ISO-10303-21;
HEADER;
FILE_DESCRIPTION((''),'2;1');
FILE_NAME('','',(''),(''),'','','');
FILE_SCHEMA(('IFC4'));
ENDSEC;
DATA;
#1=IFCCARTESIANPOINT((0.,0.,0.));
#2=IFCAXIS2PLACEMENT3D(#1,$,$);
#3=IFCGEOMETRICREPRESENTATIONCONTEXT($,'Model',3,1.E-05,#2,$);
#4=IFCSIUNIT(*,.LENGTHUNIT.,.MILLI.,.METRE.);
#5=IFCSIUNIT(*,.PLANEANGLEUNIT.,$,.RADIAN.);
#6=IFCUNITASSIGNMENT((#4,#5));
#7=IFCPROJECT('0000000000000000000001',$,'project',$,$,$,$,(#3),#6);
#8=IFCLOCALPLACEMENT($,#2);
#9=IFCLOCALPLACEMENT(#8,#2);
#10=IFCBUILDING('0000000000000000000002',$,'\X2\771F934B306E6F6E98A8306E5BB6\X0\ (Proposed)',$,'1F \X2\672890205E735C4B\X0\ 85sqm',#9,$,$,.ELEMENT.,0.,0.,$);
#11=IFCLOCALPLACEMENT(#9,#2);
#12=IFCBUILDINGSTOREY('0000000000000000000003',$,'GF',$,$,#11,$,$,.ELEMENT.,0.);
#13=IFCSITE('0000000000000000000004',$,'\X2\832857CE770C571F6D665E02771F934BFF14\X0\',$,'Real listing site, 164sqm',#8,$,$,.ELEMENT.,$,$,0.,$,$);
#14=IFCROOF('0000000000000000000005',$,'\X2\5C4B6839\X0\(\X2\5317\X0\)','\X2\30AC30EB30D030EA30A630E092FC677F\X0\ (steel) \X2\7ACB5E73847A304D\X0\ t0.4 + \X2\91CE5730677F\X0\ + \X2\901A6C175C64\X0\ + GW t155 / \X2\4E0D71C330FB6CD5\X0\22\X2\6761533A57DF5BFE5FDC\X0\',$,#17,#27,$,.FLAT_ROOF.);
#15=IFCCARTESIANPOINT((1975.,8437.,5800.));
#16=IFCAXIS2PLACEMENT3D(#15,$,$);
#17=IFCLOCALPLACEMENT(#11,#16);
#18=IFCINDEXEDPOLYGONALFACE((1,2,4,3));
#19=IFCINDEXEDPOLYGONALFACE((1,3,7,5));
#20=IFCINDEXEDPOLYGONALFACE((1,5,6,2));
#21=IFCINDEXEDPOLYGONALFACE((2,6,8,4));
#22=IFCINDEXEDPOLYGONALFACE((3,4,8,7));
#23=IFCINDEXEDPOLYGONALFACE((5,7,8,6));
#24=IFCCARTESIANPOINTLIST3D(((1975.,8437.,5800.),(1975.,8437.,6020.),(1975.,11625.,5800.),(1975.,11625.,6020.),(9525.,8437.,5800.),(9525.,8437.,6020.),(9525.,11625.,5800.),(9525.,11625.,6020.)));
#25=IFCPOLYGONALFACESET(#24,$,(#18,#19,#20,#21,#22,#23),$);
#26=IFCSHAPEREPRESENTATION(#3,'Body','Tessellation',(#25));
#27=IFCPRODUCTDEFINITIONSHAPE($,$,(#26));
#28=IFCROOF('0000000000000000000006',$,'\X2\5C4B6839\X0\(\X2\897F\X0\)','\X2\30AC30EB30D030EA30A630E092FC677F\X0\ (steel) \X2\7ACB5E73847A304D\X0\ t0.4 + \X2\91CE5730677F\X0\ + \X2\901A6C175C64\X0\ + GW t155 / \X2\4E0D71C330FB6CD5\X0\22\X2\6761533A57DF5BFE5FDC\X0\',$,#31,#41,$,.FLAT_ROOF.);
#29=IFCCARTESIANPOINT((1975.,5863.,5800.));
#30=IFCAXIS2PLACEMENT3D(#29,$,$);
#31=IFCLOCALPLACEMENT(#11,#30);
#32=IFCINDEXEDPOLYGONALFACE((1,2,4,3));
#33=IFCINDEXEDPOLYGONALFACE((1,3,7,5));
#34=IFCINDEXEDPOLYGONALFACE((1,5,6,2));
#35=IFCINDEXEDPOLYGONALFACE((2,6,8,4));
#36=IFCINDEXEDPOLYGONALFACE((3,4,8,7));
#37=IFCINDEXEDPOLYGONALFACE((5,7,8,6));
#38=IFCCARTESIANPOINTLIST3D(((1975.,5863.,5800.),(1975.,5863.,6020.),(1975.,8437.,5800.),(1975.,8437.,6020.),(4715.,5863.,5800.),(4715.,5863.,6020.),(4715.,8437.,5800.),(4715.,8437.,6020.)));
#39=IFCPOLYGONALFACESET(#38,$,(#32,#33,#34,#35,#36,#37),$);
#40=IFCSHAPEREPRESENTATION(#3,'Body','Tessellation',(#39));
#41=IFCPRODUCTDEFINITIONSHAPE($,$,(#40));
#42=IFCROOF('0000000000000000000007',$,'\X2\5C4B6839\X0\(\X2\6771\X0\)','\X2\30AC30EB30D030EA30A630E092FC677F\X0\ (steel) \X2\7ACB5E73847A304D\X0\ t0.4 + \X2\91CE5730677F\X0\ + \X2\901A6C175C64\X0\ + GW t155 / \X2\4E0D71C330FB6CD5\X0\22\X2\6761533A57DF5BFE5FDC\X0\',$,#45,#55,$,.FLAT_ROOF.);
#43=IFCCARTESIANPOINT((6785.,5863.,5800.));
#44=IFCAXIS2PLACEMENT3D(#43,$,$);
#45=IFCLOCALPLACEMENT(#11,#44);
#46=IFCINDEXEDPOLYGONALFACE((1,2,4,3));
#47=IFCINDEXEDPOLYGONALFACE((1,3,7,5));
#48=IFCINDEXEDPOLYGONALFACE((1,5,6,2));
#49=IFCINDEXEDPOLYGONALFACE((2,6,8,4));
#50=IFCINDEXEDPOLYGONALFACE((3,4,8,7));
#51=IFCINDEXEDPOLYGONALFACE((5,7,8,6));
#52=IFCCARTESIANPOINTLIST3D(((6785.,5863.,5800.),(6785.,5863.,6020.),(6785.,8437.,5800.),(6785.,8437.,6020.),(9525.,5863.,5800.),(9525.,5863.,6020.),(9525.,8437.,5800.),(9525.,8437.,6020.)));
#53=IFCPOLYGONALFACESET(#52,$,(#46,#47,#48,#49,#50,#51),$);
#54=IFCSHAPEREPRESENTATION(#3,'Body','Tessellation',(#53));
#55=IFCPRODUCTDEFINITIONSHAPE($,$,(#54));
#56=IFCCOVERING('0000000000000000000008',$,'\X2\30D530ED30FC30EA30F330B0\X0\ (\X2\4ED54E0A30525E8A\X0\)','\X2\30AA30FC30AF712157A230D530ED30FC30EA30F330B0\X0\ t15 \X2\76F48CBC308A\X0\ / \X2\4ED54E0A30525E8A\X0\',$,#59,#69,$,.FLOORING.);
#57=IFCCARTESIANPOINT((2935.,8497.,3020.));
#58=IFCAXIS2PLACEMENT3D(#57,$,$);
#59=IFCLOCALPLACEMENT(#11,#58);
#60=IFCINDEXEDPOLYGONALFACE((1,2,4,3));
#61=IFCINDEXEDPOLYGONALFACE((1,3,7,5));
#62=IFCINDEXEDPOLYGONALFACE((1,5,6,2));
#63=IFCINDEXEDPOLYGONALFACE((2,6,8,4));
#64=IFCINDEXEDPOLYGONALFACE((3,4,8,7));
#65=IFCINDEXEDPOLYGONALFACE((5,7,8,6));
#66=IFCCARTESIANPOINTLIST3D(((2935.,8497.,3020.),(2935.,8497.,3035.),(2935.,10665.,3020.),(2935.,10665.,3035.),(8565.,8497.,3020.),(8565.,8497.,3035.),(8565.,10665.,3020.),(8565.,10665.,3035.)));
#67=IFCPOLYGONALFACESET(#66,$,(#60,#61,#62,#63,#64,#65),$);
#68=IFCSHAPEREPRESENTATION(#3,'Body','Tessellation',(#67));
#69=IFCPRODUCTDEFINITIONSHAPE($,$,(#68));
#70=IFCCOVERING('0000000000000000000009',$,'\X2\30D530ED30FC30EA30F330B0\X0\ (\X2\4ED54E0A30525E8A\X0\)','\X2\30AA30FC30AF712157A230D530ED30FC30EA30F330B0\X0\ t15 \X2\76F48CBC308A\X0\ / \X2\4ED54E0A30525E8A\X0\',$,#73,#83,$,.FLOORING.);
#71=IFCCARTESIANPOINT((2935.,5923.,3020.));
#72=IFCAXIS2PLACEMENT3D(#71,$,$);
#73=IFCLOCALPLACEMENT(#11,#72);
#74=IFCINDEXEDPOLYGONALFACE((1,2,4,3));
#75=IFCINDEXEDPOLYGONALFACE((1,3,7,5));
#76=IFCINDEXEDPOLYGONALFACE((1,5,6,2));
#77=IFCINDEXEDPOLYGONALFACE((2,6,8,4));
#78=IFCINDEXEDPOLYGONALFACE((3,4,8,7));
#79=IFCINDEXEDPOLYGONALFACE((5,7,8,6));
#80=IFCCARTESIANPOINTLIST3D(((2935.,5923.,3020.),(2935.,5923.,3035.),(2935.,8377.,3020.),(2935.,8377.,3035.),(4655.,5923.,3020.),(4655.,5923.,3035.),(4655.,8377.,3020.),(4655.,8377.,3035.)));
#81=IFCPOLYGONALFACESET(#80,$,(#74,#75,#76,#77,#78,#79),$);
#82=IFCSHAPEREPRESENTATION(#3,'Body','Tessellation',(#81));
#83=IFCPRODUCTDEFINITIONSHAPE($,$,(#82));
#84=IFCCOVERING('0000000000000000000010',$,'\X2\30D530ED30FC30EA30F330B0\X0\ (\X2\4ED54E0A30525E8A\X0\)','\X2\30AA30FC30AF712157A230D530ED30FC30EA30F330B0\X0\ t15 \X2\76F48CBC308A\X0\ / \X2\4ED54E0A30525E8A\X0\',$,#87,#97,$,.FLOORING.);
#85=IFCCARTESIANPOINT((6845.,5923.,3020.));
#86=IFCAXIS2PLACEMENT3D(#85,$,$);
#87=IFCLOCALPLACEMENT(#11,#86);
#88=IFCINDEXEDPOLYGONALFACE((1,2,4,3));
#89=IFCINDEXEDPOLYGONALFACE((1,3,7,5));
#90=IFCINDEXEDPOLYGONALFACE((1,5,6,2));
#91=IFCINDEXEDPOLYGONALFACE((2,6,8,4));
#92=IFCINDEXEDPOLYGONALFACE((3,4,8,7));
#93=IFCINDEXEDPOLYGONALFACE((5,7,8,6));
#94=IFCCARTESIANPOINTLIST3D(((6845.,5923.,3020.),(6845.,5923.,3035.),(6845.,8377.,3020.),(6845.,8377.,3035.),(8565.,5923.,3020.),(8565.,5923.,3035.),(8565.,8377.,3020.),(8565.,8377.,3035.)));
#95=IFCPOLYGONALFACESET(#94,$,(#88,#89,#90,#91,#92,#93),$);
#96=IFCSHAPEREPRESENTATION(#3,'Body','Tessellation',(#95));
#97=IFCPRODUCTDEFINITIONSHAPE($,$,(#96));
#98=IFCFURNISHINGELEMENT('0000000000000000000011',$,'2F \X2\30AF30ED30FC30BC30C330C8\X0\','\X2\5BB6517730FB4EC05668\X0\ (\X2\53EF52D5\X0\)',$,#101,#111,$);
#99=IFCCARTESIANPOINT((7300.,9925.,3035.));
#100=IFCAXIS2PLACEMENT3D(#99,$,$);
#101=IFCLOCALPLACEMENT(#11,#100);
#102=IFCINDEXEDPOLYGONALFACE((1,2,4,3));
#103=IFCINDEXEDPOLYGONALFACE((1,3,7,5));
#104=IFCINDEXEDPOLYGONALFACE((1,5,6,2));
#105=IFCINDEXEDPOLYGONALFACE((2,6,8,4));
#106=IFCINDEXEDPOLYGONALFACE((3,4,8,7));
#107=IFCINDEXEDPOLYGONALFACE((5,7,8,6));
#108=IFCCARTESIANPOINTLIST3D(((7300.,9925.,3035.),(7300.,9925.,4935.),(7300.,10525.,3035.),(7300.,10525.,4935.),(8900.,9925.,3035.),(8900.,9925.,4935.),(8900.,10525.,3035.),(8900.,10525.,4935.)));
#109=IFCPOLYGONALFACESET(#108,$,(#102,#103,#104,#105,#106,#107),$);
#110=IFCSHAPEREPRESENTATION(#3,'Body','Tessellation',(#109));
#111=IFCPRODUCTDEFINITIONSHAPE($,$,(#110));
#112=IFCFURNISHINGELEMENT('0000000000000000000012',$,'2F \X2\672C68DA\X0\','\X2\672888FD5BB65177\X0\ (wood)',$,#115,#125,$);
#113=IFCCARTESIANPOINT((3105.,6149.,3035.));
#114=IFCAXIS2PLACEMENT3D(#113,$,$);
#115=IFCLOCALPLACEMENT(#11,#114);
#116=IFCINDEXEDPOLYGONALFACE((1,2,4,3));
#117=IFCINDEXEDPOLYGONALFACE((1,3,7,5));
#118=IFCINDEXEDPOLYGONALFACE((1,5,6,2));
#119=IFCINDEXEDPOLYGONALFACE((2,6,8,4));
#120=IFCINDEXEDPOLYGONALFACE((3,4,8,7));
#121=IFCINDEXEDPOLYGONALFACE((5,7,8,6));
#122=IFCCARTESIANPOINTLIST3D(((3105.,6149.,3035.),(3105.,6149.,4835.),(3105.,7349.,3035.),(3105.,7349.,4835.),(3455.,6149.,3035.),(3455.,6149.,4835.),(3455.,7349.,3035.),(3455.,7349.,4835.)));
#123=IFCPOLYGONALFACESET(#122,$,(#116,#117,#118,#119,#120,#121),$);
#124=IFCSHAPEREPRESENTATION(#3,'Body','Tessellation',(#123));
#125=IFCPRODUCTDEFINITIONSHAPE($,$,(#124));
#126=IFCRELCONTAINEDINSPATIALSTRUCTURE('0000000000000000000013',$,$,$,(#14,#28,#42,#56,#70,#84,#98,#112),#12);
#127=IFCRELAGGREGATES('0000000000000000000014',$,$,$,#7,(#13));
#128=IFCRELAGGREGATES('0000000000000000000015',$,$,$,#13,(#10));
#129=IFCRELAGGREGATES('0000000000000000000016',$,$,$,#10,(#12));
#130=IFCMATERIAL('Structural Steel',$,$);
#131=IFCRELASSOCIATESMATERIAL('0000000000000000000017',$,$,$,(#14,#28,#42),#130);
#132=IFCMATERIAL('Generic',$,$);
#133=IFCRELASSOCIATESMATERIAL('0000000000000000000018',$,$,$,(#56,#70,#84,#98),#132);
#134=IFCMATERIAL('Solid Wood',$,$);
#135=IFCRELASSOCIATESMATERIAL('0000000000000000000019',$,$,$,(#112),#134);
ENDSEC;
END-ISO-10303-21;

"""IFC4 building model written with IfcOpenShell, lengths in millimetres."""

from ifc_helpers import new_model, si_unit, frame, frame_2d, origin, place, context, project, spatial, rectangle, extrude, material, element, save


model = new_model("IFC4")

# Units and contexts
model_context = context("Model", 3, precision=1e-05, world=origin())
ifc_project = project(units=[si_unit("LENGTHUNIT", "METRE", prefix="MILLI"), si_unit("PLANEANGLEUNIT", "RADIAN")], contexts=[model_context])

# Site, building, storey
site_placement = place(None, origin())
site = spatial("IfcSite", under=ifc_project, at=site_placement, Name="茨城県土浦市真鍋４", ObjectType="Real listing site, 164sqm", CompositionType="ELEMENT", RefElevation=0.0)
building_placement = place(site_placement, origin())
building = spatial("IfcBuilding", under=site, at=building_placement, Name="真鍋の潮風の家 (Proposed)", ObjectType="1F 木造平屋 85sqm", CompositionType="ELEMENT", ElevationOfRefHeight=0.0, ElevationOfTerrain=0.0)
storey_placement = place(building_placement, origin())
storey = spatial("IfcBuildingStorey", under=building, at=storey_placement, Name="GF", CompositionType="ELEMENT", Elevation=0.0)

# Shared definitions
ifc_material_1 = material(Name="Solid Wood")

# Shared definitions
ifc_material_2 = material(Name="Generic")

# Roofs
ifc_material_3 = material(Name="Structural Steel")
for number, where, name in (
    (1, (1975.0, 8437.0, 5800.0), "屋根(北)"),
):
    element("IfcRoof", number, at=place(storey_placement, frame(where)), inside=storey, material=ifc_material_3, Name=name, Description="ガルバリウム鋼板 (steel) 立平葺き t0.4 + 野地板 + 通気層 + GW t155 / 不燃・法22条区域対応", PredefinedType="FLAT_ROOF", context=model_context, shape_type="SweptSolid", body=[
        extrude(rectangle(XDim=7550.0, YDim=3188.0, at=frame_2d((3775.0, 1594.0))), frame((1975.0, 8437.0, 5800.0)), (0.0, 0.0, 1.0), 220.0),
    ])
roof_1_placement = place(storey_placement, frame((1975.0, 5863.0, 5800.0)))
element("IfcRoof", 2, at=roof_1_placement, inside=storey, material=ifc_material_3, Name="屋根(西)", Description="ガルバリウム鋼板 (steel) 立平葺き t0.4 + 野地板 + 通気層 + GW t155 / 不燃・法22条区域対応", PredefinedType="FLAT_ROOF", context=model_context, shape_type="SweptSolid", body=[
    extrude(rectangle(XDim=2740.0, YDim=2574.0, at=frame_2d((1370.0, 1287.0))), frame((1975.0, 5863.0, 5800.0)), (0.0, 0.0, 1.0), 220.0),
])
roof_2_placement = place(storey_placement, frame((6785.0, 5863.0, 5800.0)))
element("IfcRoof", 3, at=roof_2_placement, inside=storey, material=ifc_material_3, Name="屋根(東)", Description="ガルバリウム鋼板 (steel) 立平葺き t0.4 + 野地板 + 通気層 + GW t155 / 不燃・法22条区域対応", PredefinedType="FLAT_ROOF", context=model_context, shape_type="SweptSolid", body=[
    extrude(rectangle(XDim=2740.0, YDim=2574.0, at=frame_2d((1370.0, 1287.0))), frame((6785.0, 5863.0, 5800.0)), (0.0, 0.0, 1.0), 220.0),
])

# Coverings
covering_1_placement = place(storey_placement, frame((2935.0, 8497.0, 3020.0)))
element("IfcCovering", 4, at=covering_1_placement, inside=storey, material=ifc_material_2, Name="フローリング (仕上げ床)", Description="オーク無垢フローリング t15 直貼り / 仕上げ床", PredefinedType="FLOORING", context=model_context, shape_type="SweptSolid", body=[
    extrude(rectangle(XDim=5630.0, YDim=2168.0, at=frame_2d((2815.0, 1084.0))), frame((2935.0, 8497.0, 3020.0)), (0.0, 0.0, 1.0), 15.0),
])
covering_2_placement = place(storey_placement, frame((2935.0, 5923.0, 3020.0)))
element("IfcCovering", 5, at=covering_2_placement, inside=storey, material=ifc_material_2, Name="フローリング (仕上げ床)", Description="オーク無垢フローリング t15 直貼り / 仕上げ床", PredefinedType="FLOORING", context=model_context, shape_type="SweptSolid", body=[
    extrude(rectangle(XDim=1720.0, YDim=2454.0, at=frame_2d((860.0, 1227.0))), frame((2935.0, 5923.0, 3020.0)), (0.0, 0.0, 1.0), 15.0),
])
covering_3_placement = place(storey_placement, frame((6845.0, 5923.0, 3020.0)))
element("IfcCovering", 6, at=covering_3_placement, inside=storey, material=ifc_material_2, Name="フローリング (仕上げ床)", Description="オーク無垢フローリング t15 直貼り / 仕上げ床", PredefinedType="FLOORING", context=model_context, shape_type="SweptSolid", body=[
    extrude(rectangle(XDim=1720.0, YDim=2454.0, at=frame_2d((860.0, 1227.0))), frame((6845.0, 5923.0, 3020.0)), (0.0, 0.0, 1.0), 15.0),
])

# Furnishing elements
furnishing_1_placement = place(storey_placement, frame((7300.0, 9925.0, 3035.0)))
element("IfcFurnishingElement", 7, at=furnishing_1_placement, inside=storey, material=ifc_material_2, Name="2F クローゼット", Description="家具・什器 (可動)", context=model_context, shape_type="SweptSolid", body=[
    extrude(rectangle(XDim=1600.0, YDim=600.0, at=frame_2d((800.0, 300.0))), frame((7300.0, 9925.0, 3035.0)), (0.0, 0.0, 1.0), 1900.0),
])
furnishing_2_placement = place(storey_placement, frame((3105.0, 6149.0, 3035.0)))
element("IfcFurnishingElement", 8, at=furnishing_2_placement, inside=storey, material=ifc_material_1, Name="2F 本棚", Description="木製家具 (wood)", context=model_context, shape_type="SweptSolid", body=[
    extrude(rectangle(XDim=350.0, YDim=1200.0, at=frame_2d((175.0, 600.0))), frame((3105.0, 6149.0, 3035.0)), (0.0, 0.0, 1.0), 1800.0),
])

save(model, "model.ifc")
